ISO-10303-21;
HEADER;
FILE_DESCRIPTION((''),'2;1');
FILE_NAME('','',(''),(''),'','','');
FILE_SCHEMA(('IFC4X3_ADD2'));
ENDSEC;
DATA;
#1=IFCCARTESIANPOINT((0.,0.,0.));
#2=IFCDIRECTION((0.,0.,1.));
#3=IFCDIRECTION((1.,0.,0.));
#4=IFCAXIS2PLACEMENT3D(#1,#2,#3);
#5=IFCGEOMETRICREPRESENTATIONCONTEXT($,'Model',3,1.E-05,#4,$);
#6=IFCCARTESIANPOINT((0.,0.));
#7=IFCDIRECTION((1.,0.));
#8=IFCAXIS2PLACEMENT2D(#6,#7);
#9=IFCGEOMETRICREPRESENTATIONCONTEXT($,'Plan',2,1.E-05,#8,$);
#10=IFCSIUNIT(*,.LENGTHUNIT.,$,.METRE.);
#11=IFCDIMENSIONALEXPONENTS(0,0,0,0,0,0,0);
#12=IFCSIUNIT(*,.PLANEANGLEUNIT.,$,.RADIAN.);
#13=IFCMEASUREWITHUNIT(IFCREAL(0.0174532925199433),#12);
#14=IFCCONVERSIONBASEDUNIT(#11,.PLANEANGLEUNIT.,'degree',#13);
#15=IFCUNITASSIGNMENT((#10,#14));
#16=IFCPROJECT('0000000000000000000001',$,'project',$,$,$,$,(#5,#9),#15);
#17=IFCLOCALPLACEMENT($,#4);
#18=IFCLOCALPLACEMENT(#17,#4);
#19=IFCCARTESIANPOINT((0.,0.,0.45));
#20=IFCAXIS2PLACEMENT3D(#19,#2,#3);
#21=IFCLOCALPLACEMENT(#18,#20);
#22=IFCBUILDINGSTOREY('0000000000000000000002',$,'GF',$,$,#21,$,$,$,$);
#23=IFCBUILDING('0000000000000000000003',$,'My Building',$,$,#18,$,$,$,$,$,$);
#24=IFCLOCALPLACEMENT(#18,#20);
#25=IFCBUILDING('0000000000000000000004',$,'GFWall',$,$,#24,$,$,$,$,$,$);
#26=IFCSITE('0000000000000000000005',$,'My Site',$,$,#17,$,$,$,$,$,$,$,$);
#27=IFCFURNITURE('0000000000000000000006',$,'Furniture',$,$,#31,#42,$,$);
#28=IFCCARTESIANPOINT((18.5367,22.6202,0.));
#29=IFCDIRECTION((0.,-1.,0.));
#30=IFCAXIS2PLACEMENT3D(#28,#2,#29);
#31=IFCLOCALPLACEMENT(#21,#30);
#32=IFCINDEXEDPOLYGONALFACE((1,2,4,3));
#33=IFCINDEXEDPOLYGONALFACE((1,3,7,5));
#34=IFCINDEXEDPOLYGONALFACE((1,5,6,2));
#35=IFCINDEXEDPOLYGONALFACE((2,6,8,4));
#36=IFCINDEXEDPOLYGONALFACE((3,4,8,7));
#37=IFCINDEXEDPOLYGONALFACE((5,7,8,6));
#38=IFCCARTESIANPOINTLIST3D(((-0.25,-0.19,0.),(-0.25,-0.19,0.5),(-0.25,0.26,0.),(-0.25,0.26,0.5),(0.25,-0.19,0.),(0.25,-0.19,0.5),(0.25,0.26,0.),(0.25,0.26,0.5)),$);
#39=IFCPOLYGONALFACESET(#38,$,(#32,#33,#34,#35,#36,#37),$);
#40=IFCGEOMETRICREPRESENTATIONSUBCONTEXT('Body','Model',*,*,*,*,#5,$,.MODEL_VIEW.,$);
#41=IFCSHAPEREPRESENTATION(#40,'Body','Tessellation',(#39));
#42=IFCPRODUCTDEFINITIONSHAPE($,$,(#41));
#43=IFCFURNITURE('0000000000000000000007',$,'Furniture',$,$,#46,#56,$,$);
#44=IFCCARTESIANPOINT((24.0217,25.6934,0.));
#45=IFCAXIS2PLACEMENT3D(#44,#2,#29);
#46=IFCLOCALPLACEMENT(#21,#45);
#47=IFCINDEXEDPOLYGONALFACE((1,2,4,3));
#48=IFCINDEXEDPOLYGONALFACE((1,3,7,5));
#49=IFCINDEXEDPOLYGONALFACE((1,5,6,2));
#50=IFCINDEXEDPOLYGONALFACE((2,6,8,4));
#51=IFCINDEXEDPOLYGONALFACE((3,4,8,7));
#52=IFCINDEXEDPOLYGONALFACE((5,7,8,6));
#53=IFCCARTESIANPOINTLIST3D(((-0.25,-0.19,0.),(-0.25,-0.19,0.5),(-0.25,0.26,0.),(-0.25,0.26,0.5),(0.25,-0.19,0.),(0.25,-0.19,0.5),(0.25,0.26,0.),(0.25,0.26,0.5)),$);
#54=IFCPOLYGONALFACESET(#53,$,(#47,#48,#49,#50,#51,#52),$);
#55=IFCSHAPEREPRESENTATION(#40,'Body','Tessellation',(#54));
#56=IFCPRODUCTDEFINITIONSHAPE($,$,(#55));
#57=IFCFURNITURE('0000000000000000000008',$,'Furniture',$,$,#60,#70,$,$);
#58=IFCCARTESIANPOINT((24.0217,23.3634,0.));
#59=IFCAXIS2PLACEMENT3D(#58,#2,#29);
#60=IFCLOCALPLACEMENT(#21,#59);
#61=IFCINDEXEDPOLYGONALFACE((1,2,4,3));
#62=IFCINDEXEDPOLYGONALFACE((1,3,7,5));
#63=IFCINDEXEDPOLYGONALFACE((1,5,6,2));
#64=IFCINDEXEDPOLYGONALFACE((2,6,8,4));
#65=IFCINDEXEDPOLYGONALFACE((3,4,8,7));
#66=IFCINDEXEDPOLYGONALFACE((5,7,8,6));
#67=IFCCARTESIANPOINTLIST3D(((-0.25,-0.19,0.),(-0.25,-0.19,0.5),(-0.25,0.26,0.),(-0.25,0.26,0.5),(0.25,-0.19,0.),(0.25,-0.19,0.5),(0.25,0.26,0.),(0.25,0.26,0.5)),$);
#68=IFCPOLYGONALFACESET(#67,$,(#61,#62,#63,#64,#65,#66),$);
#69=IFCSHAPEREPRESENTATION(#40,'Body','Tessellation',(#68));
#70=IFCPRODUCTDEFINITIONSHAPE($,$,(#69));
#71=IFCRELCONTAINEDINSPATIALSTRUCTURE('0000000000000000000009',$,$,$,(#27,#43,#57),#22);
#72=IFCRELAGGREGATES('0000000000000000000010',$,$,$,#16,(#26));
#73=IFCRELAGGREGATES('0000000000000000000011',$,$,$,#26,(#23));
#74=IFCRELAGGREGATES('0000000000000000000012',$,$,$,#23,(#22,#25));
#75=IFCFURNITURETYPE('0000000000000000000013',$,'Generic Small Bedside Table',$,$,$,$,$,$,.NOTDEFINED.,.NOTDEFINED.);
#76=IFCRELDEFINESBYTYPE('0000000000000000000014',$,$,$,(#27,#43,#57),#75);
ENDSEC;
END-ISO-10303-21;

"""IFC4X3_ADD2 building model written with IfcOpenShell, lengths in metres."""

from ifc_helpers import new_model, entity, si_unit, converted_unit, frame, origin_with_axes, origin_2d_with_axis, place, context, subcontext, project, spatial, indexed_curve, outline, extrude, shape, source, transform, mapped, type_object, type_shapes, element, save


model = new_model("IFC4X3_ADD2")

# Units and contexts
model_context = context("Model", 3, precision=1e-05, world=origin_with_axes())
plan_context = context("Plan", 2, precision=1e-05, world=origin_2d_with_axis())
body_context_1 = subcontext(model_context, "Body", "Model", "MODEL_VIEW")
body_context_2 = subcontext(plan_context, "Body", "Plan", "PLAN_VIEW")
ifc_project = project(units=[si_unit("LENGTHUNIT", "METRE"), converted_unit("PLANEANGLEUNIT", "degree", entity("IfcReal", 0.0174532925199433), si_unit("PLANEANGLEUNIT", "RADIAN"), dimensions=[0, 0, 0, 0, 0, 0, 0])], contexts=[model_context, plan_context])

# Site, building, storey
site_placement = place(None, origin_with_axes())
site = spatial("IfcSite", under=ifc_project, at=site_placement, Name="My Site")
building_1_placement = place(site_placement, origin_with_axes())
building_1 = spatial("IfcBuilding", under=site, at=building_1_placement, Name="My Building")
storey_placement = place(building_1_placement, frame((0.0, 0.0, 0.45), z_axis=(0.0, 0.0, 1.0), x_axis=(1.0, 0.0, 0.0)))
storey = spatial("IfcBuildingStorey", under=building_1, at=storey_placement, Name="GF")

# Shared definitions
building_2_placement = place(building_1_placement, frame((0.0, 0.0, 0.45), z_axis=(0.0, 0.0, 1.0), x_axis=(1.0, 0.0, 0.0)))
building_2 = spatial("IfcBuilding", under=building_1, at=building_2_placement, Name="GFWall")

# Furniture
furniture_type_1 = type_object("IfcFurnitureType", Name="Generic Small Bedside Table", AssemblyPlace="NOTDEFINED", PredefinedType="NOTDEFINED")
shared_shape_1 = source(origin_with_axes(), body_context_1, "Body", "SweptSolid", [
    extrude(outline(indexed_curve([(0.0, 0.0), (0.5, 0.0), (0.5, 0.45), (0.0, 0.45), (0.0, 0.0)])), frame((-0.25, -0.19, 0.0), z_axis=(0.0, 0.0, 1.0), x_axis=(1.0, 0.0, 0.0)), (0.0, 0.0, 1.0), 0.5),
])
shared_shape_2 = source(origin_with_axes(), body_context_2, "Body", "Annotation2D", [
    entity("IfcGeometricCurveSet", [entity("IfcIndexedPolyCurve", entity("IfcCartesianPointList2D", [[-0.25, -0.19], [0.25, -0.19], [0.25, 0.26], [-0.25, 0.26]]), [entity("IfcLineIndex", [1, 2]), entity("IfcLineIndex", [2, 3]), entity("IfcLineIndex", [3, 4]), entity("IfcLineIndex", [4, 1])])]),
])
type_shapes(furniture_type_1, [shared_shape_1, shared_shape_2])
for number, where, z_axis, x_axis, name in (
    (1, (18.5367, 22.6202, 0.0), (0.0, 0.0, 1.0), (0.0, -1.0, 0.0), "Furniture"),
    (2, (24.0217, 25.6934, 0.0), (0.0, 0.0, 1.0), (0.0, -1.0, 0.0), "Furniture"),
    (3, (24.0217, 23.3634, 0.0), (0.0, 0.0, 1.0), (0.0, -1.0, 0.0), "Furniture"),
):
    element("IfcFurniture", number, at=place(storey_placement, frame(where, z_axis=z_axis, x_axis=x_axis)), inside=storey, type_object=furniture_type_1, Name=name, shapes=[
        shape(body_context_1, "Body", "MappedRepresentation", [mapped(shared_shape_1, transform((0.0, 0.0, 0.0), x_axis=(1.0, 0.0, 0.0), y_axis=(0.0, 1.0, 0.0), z_axis=(0.0, 0.0, 1.0), scale=1.0))]),
        shape(body_context_2, "Body", "MappedRepresentation", [mapped(shared_shape_2, transform((0.0, 0.0, 0.0), x_axis=(1.0, 0.0, 0.0), y_axis=(0.0, 1.0, 0.0), z_axis=(0.0, 0.0, 1.0), scale=1.0))]),
    ])

save(model, "model.ifc")
